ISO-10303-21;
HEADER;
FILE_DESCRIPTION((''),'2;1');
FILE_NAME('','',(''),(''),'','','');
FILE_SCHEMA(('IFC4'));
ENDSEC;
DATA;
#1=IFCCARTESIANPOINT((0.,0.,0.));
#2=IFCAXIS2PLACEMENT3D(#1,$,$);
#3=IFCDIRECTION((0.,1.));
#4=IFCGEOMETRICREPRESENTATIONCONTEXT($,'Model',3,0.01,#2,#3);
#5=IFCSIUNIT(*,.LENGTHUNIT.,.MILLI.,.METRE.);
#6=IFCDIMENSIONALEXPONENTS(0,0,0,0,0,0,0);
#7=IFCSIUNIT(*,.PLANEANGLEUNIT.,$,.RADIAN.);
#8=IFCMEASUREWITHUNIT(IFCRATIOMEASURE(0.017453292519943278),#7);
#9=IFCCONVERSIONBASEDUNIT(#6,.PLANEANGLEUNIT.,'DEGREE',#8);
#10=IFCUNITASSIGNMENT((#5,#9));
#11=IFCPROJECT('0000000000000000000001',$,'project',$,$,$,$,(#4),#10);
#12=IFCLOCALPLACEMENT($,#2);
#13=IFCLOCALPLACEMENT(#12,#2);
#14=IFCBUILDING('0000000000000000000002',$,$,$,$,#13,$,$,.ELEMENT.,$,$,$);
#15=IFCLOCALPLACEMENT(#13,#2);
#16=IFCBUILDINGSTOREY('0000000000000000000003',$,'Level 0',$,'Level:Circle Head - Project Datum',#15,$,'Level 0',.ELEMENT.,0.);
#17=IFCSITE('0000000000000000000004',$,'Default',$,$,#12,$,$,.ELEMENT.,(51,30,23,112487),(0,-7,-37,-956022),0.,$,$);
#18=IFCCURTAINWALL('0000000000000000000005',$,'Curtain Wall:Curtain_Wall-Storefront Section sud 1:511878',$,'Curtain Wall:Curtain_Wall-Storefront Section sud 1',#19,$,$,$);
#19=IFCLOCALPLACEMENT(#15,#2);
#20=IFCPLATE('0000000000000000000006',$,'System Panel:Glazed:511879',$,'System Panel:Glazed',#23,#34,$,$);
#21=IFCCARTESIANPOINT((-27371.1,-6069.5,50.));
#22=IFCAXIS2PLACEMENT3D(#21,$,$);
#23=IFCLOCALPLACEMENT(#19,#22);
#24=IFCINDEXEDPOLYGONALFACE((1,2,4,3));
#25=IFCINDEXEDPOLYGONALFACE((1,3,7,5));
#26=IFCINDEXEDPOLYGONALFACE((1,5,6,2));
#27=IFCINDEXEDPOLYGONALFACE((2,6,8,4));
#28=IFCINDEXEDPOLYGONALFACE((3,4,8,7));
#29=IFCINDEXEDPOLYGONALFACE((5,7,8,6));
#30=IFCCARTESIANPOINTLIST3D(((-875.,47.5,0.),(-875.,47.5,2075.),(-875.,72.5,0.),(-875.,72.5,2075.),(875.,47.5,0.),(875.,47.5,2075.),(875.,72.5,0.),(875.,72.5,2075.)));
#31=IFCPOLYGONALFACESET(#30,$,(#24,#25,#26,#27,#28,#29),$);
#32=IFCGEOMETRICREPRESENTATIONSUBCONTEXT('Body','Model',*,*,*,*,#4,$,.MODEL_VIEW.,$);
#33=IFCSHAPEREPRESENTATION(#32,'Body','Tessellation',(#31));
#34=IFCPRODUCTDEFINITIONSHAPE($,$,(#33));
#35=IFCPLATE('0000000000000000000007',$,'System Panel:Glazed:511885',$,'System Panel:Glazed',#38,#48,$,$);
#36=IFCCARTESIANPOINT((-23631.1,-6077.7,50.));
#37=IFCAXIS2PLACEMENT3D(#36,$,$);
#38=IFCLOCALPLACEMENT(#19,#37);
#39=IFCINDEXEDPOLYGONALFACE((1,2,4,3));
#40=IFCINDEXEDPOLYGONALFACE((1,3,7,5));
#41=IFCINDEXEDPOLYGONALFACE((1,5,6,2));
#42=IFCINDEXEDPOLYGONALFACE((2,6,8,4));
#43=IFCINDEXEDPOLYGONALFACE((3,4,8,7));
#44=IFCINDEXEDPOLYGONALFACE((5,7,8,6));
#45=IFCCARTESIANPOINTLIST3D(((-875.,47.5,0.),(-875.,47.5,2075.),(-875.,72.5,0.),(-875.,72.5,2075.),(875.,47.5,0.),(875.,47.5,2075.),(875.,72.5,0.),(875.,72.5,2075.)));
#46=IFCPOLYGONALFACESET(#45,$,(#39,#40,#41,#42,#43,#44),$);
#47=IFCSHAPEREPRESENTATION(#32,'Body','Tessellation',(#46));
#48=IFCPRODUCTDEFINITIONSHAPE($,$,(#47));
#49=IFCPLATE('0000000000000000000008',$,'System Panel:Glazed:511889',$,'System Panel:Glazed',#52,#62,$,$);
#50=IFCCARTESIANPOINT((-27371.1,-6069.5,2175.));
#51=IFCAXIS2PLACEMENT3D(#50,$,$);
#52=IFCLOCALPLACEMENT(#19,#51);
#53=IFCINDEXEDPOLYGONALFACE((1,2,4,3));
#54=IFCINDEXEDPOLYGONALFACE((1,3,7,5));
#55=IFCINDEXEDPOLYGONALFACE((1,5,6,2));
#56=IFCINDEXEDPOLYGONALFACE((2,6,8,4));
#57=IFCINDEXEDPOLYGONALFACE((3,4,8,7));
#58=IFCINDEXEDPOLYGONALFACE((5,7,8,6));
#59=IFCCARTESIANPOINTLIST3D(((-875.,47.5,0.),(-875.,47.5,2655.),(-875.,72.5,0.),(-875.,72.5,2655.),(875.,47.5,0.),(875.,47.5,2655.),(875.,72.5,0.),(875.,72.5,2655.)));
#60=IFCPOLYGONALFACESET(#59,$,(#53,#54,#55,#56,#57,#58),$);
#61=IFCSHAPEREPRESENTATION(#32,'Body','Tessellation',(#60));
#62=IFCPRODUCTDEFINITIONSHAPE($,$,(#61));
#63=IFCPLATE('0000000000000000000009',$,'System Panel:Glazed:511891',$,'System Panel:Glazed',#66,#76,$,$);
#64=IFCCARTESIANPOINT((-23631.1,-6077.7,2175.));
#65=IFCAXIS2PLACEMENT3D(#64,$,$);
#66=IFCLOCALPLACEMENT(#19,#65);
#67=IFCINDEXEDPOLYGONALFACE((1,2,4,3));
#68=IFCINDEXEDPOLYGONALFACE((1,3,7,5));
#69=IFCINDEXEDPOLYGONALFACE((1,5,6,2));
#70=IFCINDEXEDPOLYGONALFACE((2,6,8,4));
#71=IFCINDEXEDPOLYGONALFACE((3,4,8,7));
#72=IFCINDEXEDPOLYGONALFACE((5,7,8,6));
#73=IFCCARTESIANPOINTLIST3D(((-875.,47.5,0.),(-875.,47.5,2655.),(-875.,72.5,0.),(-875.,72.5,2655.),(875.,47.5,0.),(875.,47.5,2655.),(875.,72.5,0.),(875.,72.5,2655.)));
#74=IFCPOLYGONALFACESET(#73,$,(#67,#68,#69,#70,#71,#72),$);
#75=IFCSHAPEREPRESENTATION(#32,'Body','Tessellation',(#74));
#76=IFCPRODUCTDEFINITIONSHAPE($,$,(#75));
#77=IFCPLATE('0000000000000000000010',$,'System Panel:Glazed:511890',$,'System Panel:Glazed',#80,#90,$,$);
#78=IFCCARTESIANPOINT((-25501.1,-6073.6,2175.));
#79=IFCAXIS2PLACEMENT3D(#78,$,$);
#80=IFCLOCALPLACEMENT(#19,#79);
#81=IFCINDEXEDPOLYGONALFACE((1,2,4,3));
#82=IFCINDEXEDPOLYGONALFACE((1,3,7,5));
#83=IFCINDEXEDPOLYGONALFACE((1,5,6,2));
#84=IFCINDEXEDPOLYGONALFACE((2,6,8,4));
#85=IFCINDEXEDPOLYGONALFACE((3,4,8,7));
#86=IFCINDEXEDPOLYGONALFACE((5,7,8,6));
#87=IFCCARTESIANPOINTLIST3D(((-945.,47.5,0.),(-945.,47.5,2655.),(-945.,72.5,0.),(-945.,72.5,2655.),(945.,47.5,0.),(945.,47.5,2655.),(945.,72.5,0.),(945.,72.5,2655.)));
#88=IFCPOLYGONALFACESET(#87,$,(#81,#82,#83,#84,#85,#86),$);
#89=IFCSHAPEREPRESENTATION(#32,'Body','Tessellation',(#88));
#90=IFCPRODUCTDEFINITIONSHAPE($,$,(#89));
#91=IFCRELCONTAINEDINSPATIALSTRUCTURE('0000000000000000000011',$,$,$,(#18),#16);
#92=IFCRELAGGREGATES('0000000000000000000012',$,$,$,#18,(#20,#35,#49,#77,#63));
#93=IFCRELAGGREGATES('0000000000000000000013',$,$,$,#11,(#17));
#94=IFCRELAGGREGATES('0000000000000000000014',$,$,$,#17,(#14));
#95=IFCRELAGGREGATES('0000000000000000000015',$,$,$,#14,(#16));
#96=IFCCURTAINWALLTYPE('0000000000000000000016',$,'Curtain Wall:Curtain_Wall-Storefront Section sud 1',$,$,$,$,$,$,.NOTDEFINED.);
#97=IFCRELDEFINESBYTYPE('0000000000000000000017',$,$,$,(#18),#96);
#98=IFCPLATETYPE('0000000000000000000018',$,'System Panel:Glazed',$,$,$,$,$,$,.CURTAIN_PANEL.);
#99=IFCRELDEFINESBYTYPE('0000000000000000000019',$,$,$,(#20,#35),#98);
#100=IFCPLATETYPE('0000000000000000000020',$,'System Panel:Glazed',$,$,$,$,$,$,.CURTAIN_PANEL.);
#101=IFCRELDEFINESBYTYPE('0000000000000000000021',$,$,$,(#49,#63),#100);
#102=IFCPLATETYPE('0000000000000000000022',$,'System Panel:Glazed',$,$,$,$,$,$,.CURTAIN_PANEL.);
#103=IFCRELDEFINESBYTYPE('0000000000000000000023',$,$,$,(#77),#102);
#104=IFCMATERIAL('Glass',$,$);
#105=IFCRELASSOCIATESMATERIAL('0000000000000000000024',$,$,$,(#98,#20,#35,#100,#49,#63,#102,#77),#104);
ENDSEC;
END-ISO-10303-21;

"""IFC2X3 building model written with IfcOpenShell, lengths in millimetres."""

from ifc_helpers import new_model, entity, si_unit, converted_unit, direction, frame, frame_2d, origin, origin_2d_with_axis, place, context, subcontext, project, spatial, rectangle, extrude, source, transform, mapped, material, type_object, type_shapes, element, aggregate, save


model = new_model("IFC2X3")

# Units and contexts
model_context = context("Model", 3, precision=0.01, world=origin(), true_north=direction((0.0, 1.0)))
body_context = subcontext(model_context, "Body", "Model", "MODEL_VIEW")
ifc_project = project(units=[si_unit("LENGTHUNIT", "METRE", prefix="MILLI"), converted_unit("PLANEANGLEUNIT", "DEGREE", entity("IfcRatioMeasure", 0.017453292519943278), si_unit("PLANEANGLEUNIT", "RADIAN"), dimensions=[0, 0, 0, 0, 0, 0, 0])], contexts=[model_context])

# Site, building, storey
site_placement = place(None, origin())
site = spatial("IfcSite", under=ifc_project, at=site_placement, Name="Default", CompositionType="ELEMENT", RefLatitude=(51, 30, 23, 112487), RefLongitude=(0, -7, -37, -956022), RefElevation=0.0)
building_placement = place(site_placement, origin())
building = spatial("IfcBuilding", under=site, at=building_placement, CompositionType="ELEMENT")
storey_placement = place(building_placement, origin())
storey = spatial("IfcBuildingStorey", under=building, at=storey_placement, Name="Level 0", ObjectType="Level:Circle Head - Project Datum", LongName="Level 0", CompositionType="ELEMENT", Elevation=0.0)

# Shared definitions
curtain_wall_type = type_object("IfcCurtainWallType", Name="Curtain Wall:Curtain_Wall-Storefront Section sud 1", PredefinedType="NOTDEFINED")

# Curtain wall
curtain_wall_1_placement = place(storey_placement, origin())
curtain_wall_1 = element("IfcCurtainWall", 1, at=curtain_wall_1_placement, inside=storey, type_object=curtain_wall_type, Name="Curtain Wall:Curtain_Wall-Storefront Section sud 1:511878", ObjectType="Curtain Wall:Curtain_Wall-Storefront Section sud 1")

# Plates
ifc_material_1 = material(Name="Glass")
plate_type_1 = type_object("IfcPlateType", Name="System Panel:Glazed", PredefinedType="CURTAIN_PANEL", material=ifc_material_1)
shared_shape_1 = source(origin(), body_context, "Body", "SweptSolid", [
    extrude(rectangle(XDim=25.0, YDim=1750.0, at=origin_2d_with_axis()), frame((0.0, 60.0, 0.0), z_axis=(0.0, 0.0, 1.0), x_axis=(0.0, 1.0, 0.0)), (0.0, 0.0, 1.0), 2075.0),
])
type_shapes(plate_type_1, [shared_shape_1])
plate_1_placement = place(curtain_wall_1_placement, frame((-27371.1, -6069.5, 50.0)))
plate_1 = element("IfcPlate", 2, at=plate_1_placement, type_object=plate_type_1, material=ifc_material_1, Name="System Panel:Glazed:511879", ObjectType="System Panel:Glazed", context=body_context, shape_type="MappedRepresentation", body=[
    mapped(shared_shape_1, transform((0.0, 0.0, 0.0), scale=1.0)),
])
plate_2_placement = place(curtain_wall_1_placement, frame((-23631.1, -6077.7, 50.0)))
plate_2 = element("IfcPlate", 3, at=plate_2_placement, type_object=plate_type_1, material=ifc_material_1, Name="System Panel:Glazed:511885", ObjectType="System Panel:Glazed", context=body_context, shape_type="MappedRepresentation", body=[
    mapped(shared_shape_1, transform((0.0, 0.0, 0.0), scale=1.0)),
])
plate_type_2 = type_object("IfcPlateType", Name="System Panel:Glazed", PredefinedType="CURTAIN_PANEL", material=ifc_material_1)
shared_shape_2 = source(origin(), body_context, "Body", "SweptSolid", [
    extrude(rectangle(XDim=25.0, YDim=1750.0, at=frame_2d((0.0, 0.0), x_axis=(1.0, 0.0))), frame((0.0, 60.0, 0.0), z_axis=(0.0, 0.0, 1.0), x_axis=(0.0, 1.0, 0.0)), (0.0, 0.0, 1.0), 2655.0),
])
type_shapes(plate_type_2, [shared_shape_2])
plate_3_placement = place(curtain_wall_1_placement, frame((-27371.1, -6069.5, 2175.0)))
plate_3 = element("IfcPlate", 4, at=plate_3_placement, type_object=plate_type_2, material=ifc_material_1, Name="System Panel:Glazed:511889", ObjectType="System Panel:Glazed", context=body_context, shape_type="MappedRepresentation", body=[
    mapped(shared_shape_2, transform((0.0, 0.0, 0.0), scale=1.0)),
])
plate_4_placement = place(curtain_wall_1_placement, frame((-23631.1, -6077.7, 2175.0)))
plate_4 = element("IfcPlate", 5, at=plate_4_placement, type_object=plate_type_2, material=ifc_material_1, Name="System Panel:Glazed:511891", ObjectType="System Panel:Glazed", context=body_context, shape_type="MappedRepresentation", body=[
    mapped(shared_shape_2, transform((0.0, 0.0, 0.0), scale=1.0)),
])
plate_type_3 = type_object("IfcPlateType", Name="System Panel:Glazed", PredefinedType="CURTAIN_PANEL", material=ifc_material_1)
shared_shape_3 = source(origin(), body_context, "Body", "SweptSolid", [
    extrude(rectangle(XDim=25.0, YDim=1890.0, at=frame_2d((0.0, 0.0), x_axis=(1.0, 0.0))), frame((0.0, 60.0, 0.0), z_axis=(0.0, 0.0, 1.0), x_axis=(0.0, 1.0, 0.0)), (0.0, 0.0, 1.0), 2655.0),
])
type_shapes(plate_type_3, [shared_shape_3])
plate_5_placement = place(curtain_wall_1_placement, frame((-25501.1, -6073.6, 2175.0)))
plate_5 = element("IfcPlate", 6, at=plate_5_placement, type_object=plate_type_3, material=ifc_material_1, Name="System Panel:Glazed:511890", ObjectType="System Panel:Glazed", context=body_context, shape_type="MappedRepresentation", body=[
    mapped(shared_shape_3, transform((0.0, 0.0, 0.0), scale=1.0)),
])
aggregate(curtain_wall_1, [plate_1, plate_2, plate_3, plate_5, plate_4])

save(model, "model.ifc")
